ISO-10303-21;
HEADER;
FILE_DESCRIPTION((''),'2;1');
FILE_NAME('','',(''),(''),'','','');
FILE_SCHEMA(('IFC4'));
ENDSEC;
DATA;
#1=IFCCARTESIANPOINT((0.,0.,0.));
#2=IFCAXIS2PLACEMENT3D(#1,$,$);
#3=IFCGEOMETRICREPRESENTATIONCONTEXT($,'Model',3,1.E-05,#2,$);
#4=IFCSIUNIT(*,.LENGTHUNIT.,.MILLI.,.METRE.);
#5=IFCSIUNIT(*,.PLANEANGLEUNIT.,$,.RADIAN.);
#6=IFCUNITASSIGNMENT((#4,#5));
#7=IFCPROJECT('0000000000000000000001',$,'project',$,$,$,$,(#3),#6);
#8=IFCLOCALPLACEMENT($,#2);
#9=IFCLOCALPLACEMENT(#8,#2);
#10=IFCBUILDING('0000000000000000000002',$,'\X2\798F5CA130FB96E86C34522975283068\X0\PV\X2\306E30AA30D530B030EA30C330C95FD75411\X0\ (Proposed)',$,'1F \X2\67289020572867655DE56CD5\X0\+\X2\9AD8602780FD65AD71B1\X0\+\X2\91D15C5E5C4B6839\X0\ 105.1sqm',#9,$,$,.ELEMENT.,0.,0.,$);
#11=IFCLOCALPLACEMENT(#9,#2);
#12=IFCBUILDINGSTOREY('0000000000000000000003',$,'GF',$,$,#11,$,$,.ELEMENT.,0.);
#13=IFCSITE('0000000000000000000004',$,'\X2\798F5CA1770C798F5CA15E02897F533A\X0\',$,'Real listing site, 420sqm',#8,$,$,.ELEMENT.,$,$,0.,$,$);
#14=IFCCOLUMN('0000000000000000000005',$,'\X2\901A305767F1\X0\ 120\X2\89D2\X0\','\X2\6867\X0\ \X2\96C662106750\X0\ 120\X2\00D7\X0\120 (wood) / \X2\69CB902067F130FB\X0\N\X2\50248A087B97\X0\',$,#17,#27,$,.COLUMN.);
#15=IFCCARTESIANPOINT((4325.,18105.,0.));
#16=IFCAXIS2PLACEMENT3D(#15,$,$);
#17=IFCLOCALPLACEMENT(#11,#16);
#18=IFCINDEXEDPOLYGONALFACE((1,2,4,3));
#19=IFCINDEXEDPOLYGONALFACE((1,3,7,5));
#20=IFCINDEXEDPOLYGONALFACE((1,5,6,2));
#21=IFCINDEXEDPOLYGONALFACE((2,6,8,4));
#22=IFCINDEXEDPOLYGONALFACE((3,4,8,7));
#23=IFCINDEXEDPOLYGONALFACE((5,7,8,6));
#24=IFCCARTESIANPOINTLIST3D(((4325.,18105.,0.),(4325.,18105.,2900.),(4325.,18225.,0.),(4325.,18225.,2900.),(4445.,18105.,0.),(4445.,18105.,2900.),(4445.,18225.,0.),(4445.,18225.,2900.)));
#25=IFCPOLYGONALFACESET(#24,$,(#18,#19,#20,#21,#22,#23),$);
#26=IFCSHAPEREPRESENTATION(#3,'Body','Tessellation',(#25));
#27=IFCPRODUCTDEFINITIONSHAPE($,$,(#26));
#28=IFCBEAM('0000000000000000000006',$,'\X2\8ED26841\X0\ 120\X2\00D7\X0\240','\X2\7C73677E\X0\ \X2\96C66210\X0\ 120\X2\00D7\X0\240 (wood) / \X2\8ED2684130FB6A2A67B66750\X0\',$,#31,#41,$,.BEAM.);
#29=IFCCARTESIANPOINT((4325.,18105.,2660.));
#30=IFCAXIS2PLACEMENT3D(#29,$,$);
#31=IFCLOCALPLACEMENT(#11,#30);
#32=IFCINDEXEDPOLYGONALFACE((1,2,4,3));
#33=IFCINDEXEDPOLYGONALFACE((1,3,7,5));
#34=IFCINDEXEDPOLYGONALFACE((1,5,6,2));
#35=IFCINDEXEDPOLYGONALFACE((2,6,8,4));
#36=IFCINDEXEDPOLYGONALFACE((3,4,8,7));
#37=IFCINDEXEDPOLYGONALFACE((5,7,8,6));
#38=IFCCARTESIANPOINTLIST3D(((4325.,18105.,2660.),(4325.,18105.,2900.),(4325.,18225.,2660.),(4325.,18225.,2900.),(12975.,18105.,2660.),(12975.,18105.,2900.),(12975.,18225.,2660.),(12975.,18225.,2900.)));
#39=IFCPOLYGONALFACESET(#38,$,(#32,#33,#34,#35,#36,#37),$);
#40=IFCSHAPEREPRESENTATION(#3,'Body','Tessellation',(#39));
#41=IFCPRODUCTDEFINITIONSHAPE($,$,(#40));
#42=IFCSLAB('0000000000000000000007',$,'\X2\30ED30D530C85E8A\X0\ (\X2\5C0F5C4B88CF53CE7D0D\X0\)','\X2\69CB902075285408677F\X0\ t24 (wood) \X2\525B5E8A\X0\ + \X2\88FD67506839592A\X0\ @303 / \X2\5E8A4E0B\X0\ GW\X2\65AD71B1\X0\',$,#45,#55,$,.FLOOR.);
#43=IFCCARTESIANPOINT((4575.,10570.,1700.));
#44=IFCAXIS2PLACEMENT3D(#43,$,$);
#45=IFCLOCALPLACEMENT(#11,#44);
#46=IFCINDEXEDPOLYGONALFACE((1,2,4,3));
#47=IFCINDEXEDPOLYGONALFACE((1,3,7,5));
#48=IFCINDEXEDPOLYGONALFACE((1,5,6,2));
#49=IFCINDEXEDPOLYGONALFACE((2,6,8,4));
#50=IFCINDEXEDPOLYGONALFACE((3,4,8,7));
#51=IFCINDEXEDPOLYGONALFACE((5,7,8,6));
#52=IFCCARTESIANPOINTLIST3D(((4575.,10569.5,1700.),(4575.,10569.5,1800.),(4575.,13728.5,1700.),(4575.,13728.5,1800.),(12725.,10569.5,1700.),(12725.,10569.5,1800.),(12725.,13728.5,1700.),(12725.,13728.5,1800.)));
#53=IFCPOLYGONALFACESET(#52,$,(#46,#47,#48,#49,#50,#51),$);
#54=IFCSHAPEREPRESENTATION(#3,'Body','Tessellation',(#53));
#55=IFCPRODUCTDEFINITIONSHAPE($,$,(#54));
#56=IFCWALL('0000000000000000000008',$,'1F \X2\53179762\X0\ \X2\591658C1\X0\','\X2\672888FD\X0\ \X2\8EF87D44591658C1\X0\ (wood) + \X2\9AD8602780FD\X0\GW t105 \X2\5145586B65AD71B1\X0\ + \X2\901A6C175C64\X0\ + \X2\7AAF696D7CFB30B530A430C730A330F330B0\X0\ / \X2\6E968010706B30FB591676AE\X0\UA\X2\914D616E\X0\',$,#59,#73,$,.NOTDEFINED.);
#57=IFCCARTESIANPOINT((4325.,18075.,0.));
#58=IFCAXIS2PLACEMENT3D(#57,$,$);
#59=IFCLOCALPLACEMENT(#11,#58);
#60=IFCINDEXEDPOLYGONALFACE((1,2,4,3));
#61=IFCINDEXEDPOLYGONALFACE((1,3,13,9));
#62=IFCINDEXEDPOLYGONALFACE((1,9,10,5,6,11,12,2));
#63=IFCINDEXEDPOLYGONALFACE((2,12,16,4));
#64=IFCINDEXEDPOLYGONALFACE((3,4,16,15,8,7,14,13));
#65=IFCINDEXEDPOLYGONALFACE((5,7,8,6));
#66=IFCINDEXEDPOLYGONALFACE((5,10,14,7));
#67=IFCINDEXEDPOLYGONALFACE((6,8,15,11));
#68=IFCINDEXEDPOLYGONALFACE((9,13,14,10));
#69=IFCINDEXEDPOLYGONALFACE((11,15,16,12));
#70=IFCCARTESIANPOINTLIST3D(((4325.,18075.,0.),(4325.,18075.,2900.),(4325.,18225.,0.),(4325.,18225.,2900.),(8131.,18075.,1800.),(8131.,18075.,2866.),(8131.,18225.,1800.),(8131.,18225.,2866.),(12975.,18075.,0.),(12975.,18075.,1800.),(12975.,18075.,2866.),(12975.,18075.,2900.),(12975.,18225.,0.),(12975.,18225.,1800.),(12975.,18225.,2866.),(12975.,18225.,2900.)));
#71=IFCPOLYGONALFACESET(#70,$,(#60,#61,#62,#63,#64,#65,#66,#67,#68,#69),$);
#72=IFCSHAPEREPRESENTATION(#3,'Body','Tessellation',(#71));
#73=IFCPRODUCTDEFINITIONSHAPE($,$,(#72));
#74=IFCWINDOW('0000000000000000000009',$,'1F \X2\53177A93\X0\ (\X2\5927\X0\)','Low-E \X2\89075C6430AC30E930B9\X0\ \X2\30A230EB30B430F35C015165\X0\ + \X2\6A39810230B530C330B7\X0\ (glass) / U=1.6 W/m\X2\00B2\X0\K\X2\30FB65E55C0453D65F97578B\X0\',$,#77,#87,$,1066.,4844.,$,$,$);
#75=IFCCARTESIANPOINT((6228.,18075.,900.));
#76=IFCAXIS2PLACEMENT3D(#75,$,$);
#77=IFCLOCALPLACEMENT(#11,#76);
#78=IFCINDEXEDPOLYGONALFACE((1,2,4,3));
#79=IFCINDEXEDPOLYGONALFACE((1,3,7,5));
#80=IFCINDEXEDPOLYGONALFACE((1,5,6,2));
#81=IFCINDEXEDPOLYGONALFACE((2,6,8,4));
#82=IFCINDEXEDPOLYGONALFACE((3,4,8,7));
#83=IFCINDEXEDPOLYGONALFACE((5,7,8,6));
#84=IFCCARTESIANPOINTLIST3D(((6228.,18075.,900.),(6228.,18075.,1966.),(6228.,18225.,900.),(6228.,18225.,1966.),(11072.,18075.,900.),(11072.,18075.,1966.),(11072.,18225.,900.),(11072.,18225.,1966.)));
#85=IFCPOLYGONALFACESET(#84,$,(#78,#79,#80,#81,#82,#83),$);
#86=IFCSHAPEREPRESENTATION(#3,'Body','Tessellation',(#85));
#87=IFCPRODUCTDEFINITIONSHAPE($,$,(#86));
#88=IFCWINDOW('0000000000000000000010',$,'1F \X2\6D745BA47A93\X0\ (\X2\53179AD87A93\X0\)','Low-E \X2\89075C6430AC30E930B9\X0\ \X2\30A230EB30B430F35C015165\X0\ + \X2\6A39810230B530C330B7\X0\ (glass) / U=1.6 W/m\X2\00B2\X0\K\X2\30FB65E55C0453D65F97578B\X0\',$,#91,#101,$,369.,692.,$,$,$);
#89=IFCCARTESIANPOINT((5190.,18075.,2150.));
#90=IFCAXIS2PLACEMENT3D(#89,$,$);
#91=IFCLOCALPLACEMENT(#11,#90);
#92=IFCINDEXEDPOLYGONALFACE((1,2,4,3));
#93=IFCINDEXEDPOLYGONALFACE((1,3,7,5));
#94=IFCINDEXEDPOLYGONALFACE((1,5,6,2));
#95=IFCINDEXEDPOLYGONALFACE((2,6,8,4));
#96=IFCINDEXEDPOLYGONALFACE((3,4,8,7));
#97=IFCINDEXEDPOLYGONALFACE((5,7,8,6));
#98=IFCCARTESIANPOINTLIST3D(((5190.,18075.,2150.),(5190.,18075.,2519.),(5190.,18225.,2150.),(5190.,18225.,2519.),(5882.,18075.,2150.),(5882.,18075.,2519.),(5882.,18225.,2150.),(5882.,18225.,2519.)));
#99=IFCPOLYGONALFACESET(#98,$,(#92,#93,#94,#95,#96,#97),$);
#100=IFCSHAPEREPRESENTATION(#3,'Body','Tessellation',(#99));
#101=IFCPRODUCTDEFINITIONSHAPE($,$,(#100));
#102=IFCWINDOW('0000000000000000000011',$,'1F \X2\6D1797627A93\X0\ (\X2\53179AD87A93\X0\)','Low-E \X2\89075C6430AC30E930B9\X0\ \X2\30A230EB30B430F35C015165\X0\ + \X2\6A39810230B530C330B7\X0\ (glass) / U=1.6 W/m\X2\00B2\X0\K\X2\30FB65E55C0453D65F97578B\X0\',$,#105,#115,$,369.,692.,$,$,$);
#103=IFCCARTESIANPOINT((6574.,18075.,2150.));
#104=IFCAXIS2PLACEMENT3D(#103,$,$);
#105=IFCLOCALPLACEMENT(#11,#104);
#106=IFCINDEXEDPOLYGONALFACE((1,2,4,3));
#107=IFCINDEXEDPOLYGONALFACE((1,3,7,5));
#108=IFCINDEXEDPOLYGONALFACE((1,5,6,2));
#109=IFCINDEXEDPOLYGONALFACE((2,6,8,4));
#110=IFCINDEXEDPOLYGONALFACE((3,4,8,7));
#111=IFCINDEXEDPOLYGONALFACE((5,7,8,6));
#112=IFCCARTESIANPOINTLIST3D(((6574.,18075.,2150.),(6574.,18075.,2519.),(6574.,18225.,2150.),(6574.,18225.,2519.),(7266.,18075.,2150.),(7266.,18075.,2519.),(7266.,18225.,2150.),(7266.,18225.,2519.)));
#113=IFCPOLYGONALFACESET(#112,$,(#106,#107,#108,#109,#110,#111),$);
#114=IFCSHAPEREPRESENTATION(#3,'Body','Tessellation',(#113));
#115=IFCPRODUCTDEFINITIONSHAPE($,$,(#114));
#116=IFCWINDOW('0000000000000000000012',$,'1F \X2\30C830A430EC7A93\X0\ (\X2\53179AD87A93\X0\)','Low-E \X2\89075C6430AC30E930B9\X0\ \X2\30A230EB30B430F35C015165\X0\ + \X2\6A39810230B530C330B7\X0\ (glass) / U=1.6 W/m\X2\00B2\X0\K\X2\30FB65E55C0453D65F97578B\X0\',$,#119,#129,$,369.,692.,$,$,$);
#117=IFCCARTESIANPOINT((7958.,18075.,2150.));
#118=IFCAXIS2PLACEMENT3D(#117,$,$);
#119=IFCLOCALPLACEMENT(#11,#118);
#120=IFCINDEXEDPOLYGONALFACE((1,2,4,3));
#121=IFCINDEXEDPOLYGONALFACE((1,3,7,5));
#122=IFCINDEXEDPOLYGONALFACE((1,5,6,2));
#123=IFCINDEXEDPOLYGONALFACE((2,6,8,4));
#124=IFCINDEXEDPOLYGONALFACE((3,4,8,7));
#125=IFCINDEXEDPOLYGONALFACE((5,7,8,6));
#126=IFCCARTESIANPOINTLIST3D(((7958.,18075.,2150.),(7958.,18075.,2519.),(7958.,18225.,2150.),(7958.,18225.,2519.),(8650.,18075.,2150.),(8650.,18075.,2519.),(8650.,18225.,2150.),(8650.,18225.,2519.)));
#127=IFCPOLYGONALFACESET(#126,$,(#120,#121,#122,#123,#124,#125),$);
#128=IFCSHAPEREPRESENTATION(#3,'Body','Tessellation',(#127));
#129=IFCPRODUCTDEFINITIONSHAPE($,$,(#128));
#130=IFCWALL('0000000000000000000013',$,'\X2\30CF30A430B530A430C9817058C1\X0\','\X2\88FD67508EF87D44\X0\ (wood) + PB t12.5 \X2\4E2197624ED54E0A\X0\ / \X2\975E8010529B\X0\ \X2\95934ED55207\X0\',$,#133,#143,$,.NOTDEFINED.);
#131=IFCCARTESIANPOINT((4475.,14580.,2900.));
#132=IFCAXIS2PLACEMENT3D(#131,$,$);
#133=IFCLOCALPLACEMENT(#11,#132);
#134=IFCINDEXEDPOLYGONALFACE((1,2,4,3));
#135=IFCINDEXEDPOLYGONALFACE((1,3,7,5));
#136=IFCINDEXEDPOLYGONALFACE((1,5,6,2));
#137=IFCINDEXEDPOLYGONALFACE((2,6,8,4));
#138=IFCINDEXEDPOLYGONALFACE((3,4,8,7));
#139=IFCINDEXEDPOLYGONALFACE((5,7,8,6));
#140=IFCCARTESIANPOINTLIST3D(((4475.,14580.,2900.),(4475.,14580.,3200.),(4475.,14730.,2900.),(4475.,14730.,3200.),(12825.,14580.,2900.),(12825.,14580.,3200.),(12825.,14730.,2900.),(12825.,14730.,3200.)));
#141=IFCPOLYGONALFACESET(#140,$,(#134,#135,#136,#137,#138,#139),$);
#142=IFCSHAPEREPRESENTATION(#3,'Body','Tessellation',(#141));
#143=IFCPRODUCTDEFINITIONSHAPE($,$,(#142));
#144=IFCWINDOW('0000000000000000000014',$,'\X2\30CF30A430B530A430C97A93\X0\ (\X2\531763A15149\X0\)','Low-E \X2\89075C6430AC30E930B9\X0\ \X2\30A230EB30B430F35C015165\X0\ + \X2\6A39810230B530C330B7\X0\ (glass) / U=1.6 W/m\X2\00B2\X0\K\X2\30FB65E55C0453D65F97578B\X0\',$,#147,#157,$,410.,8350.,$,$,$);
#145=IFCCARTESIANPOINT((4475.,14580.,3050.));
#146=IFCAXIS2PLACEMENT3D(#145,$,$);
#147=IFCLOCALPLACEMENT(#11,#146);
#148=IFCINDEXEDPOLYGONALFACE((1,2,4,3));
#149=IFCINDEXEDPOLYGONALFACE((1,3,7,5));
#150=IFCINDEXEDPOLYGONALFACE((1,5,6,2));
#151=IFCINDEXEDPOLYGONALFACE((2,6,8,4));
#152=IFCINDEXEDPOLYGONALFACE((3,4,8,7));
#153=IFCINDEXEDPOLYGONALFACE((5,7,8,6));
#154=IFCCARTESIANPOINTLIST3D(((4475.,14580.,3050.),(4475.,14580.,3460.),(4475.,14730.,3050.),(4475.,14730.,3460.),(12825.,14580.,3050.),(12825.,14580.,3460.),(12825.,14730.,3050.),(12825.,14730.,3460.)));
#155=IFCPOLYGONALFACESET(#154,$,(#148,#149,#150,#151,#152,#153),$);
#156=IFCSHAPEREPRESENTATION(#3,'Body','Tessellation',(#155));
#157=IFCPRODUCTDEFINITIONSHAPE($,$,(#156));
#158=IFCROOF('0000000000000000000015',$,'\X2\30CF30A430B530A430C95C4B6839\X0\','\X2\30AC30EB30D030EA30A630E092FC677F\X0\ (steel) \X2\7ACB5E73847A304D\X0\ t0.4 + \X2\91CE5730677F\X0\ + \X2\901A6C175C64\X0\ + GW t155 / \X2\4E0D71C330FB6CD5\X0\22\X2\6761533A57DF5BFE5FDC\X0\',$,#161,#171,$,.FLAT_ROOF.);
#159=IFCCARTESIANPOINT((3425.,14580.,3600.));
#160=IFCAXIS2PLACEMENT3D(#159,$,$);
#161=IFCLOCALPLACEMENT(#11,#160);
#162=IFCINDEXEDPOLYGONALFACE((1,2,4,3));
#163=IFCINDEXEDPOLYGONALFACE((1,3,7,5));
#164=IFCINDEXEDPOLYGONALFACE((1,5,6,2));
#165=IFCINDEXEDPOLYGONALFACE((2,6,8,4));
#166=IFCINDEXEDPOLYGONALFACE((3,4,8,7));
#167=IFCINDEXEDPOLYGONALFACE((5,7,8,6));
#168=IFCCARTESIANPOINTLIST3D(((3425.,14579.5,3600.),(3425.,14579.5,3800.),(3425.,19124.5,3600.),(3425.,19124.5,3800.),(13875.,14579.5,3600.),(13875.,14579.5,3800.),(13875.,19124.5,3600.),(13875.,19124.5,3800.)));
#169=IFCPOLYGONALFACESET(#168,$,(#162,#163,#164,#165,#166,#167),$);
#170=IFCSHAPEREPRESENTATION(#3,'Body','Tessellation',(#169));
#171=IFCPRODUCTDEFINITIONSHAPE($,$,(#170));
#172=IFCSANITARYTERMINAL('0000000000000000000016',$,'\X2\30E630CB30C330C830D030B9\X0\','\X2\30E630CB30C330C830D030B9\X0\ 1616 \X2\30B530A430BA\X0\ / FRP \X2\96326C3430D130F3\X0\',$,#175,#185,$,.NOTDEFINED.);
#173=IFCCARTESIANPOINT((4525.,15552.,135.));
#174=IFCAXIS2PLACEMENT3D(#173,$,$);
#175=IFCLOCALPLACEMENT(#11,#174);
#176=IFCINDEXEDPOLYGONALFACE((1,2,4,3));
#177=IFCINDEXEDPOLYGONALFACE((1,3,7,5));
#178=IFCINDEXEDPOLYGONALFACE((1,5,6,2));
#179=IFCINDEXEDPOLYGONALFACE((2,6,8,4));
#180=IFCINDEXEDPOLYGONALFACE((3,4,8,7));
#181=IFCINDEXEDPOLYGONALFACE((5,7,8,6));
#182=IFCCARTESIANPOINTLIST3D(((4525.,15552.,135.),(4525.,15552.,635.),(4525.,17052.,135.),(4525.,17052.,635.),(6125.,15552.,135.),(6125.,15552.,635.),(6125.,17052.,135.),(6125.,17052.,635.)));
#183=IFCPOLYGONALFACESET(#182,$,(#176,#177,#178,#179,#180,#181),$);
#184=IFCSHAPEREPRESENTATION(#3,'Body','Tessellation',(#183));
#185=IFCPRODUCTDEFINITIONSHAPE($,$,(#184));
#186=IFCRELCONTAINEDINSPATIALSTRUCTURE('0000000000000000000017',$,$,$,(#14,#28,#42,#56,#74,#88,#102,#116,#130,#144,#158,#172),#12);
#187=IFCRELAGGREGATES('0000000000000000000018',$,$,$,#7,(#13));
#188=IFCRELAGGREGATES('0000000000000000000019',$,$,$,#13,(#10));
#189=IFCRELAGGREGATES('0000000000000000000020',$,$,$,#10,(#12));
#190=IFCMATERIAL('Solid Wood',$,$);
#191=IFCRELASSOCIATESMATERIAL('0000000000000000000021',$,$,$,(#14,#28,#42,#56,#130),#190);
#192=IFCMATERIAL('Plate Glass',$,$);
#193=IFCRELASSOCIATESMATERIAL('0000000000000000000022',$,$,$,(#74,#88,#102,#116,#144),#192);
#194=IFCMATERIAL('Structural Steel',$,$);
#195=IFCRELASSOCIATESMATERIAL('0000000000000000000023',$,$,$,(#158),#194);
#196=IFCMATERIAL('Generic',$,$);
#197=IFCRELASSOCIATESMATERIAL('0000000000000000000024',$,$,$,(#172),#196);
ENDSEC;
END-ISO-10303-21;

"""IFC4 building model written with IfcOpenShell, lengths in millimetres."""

from ifc_helpers import new_model, si_unit, frame, frame_2d, origin, place, context, project, spatial, rectangle, extrude, material, element, fill, save


model = new_model("IFC4")

# Units and contexts
model_context = context("Model", 3, precision=1e-05, world=origin())
ifc_project = project(units=[si_unit("LENGTHUNIT", "METRE", prefix="MILLI"), si_unit("PLANEANGLEUNIT", "RADIAN")], contexts=[model_context])

# Site, building, storey
site_placement = place(None, origin())
site = spatial("IfcSite", under=ifc_project, at=site_placement, Name="福岡県福岡市西区", ObjectType="Real listing site, 420sqm", CompositionType="ELEMENT", RefElevation=0.0)
building_placement = place(site_placement, origin())
building = spatial("IfcBuilding", under=site, at=building_placement, Name="福岡・雨水利用とPVのオフグリッド志向 (Proposed)", ObjectType="1F 木造在来工法+高性能断熱+金属屋根 105.1sqm", CompositionType="ELEMENT", ElevationOfRefHeight=0.0, ElevationOfTerrain=0.0)
storey_placement = place(building_placement, origin())
storey = spatial("IfcBuildingStorey", under=building, at=storey_placement, Name="GF", CompositionType="ELEMENT", Elevation=0.0)

# Column
ifc_material_1 = material(Name="Solid Wood")
column_1_placement = place(storey_placement, frame((4325.0, 18105.0, 0.0)))
element("IfcColumn", 1, at=column_1_placement, inside=storey, material=ifc_material_1, Name="通し柱 120角", Description="桧 集成材 120×120 (wood) / 構造柱・N値計算", PredefinedType="COLUMN", context=model_context, shape_type="SweptSolid", body=[
    extrude(rectangle(XDim=120.0, YDim=120.0, at=frame_2d((60.0, 60.0))), frame((4325.0, 18105.0, 0.0)), (0.0, 0.0, 1.0), 2900.0),
])

# Beam
beam_1_placement = place(storey_placement, frame((4325.0, 18105.0, 2660.0)))
element("IfcBeam", 2, at=beam_1_placement, inside=storey, material=ifc_material_1, Name="軒桁 120×240", Description="米松 集成 120×240 (wood) / 軒桁・横架材", PredefinedType="BEAM", context=model_context, shape_type="SweptSolid", body=[
    extrude(rectangle(XDim=8650.0, YDim=120.0, at=frame_2d((4325.0, 60.0))), frame((4325.0, 18105.0, 2660.0)), (0.0, 0.0, 1.0), 240.0),
])

# Slab
slab_placement = place(storey_placement, frame((4575.0, 10570.0, 1700.0)))
element("IfcSlab", 3, at=slab_placement, inside=storey, material=ifc_material_1, Name="ロフト床 (小屋裏収納)", Description="構造用合板 t24 (wood) 剛床 + 製材根太 @303 / 床下 GW断熱", PredefinedType="FLOOR", context=model_context, shape_type="SweptSolid", body=[
    extrude(rectangle(XDim=8150.0, YDim=3159.0, at=frame_2d((4075.0, 1579.0))), frame((4575.0, 10570.0, 1700.0)), (0.0, 0.0, 1.0), 100.0),
])

# Wall, openings, windows
wall_1_placement = place(storey_placement, frame((4325.0, 18075.0, 0.0)))
wall_1 = element("IfcWall", 4, at=wall_1_placement, inside=storey, material=ifc_material_1, Name="1F 北面 外壁", Description="木製 軸組外壁 (wood) + 高性能GW t105 充填断熱 + 通気層 + 窯業系サイディング / 準耐火・外皮UA配慮", PredefinedType="NOTDEFINED", context=model_context, shape_type="SweptSolid", body=[
    extrude(rectangle(XDim=8650.0, YDim=150.0, at=frame_2d((4325.0, 75.0))), frame((4325.0, 18075.0, 0.0)), (0.0, 0.0, 1.0), 2900.0),
])
opening_1_placement = place(storey_placement, frame((6228.0, 18075.0, 900.0)))
opening_1 = element("IfcOpeningElement", 5, at=opening_1_placement, cuts=wall_1, PredefinedType="NOTDEFINED", context=model_context, shape_type="SweptSolid", body=[
    extrude(rectangle(XDim=4844.0, YDim=150.0, at=frame_2d((2422.0, 75.0))), frame((6228.0, 18075.0, 900.0)), (0.0, 0.0, 1.0), 1066.0),
])
opening_2_placement = place(storey_placement, frame((5190.0, 18075.0, 2150.0)))
opening_2 = element("IfcOpeningElement", 6, at=opening_2_placement, cuts=wall_1, PredefinedType="NOTDEFINED", context=model_context, shape_type="SweptSolid", body=[
    extrude(rectangle(XDim=692.0, YDim=150.0, at=frame_2d((346.0, 75.0))), frame((5190.0, 18075.0, 2150.0)), (0.0, 0.0, 1.0), 369.0),
])
opening_3_placement = place(storey_placement, frame((6574.0, 18075.0, 2150.0)))
opening_3 = element("IfcOpeningElement", 7, at=opening_3_placement, cuts=wall_1, PredefinedType="NOTDEFINED", context=model_context, shape_type="SweptSolid", body=[
    extrude(rectangle(XDim=692.0, YDim=150.0, at=frame_2d((346.0, 75.0))), frame((6574.0, 18075.0, 2150.0)), (0.0, 0.0, 1.0), 369.0),
])
opening_4_placement = place(storey_placement, frame((7958.0, 18075.0, 2150.0)))
opening_4 = element("IfcOpeningElement", 8, at=opening_4_placement, cuts=wall_1, PredefinedType="NOTDEFINED", context=model_context, shape_type="SweptSolid", body=[
    extrude(rectangle(XDim=692.0, YDim=150.0, at=frame_2d((346.0, 75.0))), frame((7958.0, 18075.0, 2150.0)), (0.0, 0.0, 1.0), 369.0),
])
ifc_material_2 = material(Name="Plate Glass")
window_1_placement = place(storey_placement, frame((6228.0, 18075.0, 900.0)))
window_1 = element("IfcWindow", 9, at=window_1_placement, inside=storey, material=ifc_material_2, Name="1F 北窓 (大)", Description="Low-E 複層ガラス アルゴン封入 + 樹脂サッシ (glass) / U=1.6 W/m²K・日射取得型", OverallHeight=1066.0, OverallWidth=4844.0, context=model_context, shape_type="SweptSolid", body=[
    extrude(rectangle(XDim=4844.0, YDim=150.0, at=frame_2d((2422.0, 75.0))), frame((6228.0, 18075.0, 900.0)), (0.0, 0.0, 1.0), 1066.0),
])
fill(opening_1, window_1)
window_2_placement = place(storey_placement, frame((5190.0, 18075.0, 2150.0)))
window_2 = element("IfcWindow", 10, at=window_2_placement, inside=storey, material=ifc_material_2, Name="1F 浴室窓 (北高窓)", Description="Low-E 複層ガラス アルゴン封入 + 樹脂サッシ (glass) / U=1.6 W/m²K・日射取得型", OverallHeight=369.0, OverallWidth=692.0, context=model_context, shape_type="SweptSolid", body=[
    extrude(rectangle(XDim=692.0, YDim=150.0, at=frame_2d((346.0, 75.0))), frame((5190.0, 18075.0, 2150.0)), (0.0, 0.0, 1.0), 369.0),
])
fill(opening_2, window_2)
window_3_placement = place(storey_placement, frame((6574.0, 18075.0, 2150.0)))
window_3 = element("IfcWindow", 11, at=window_3_placement, inside=storey, material=ifc_material_2, Name="1F 洗面窓 (北高窓)", Description="Low-E 複層ガラス アルゴン封入 + 樹脂サッシ (glass) / U=1.6 W/m²K・日射取得型", OverallHeight=369.0, OverallWidth=692.0, context=model_context, shape_type="SweptSolid", body=[
    extrude(rectangle(XDim=692.0, YDim=150.0, at=frame_2d((346.0, 75.0))), frame((6574.0, 18075.0, 2150.0)), (0.0, 0.0, 1.0), 369.0),
])
fill(opening_3, window_3)
window_4_placement = place(storey_placement, frame((7958.0, 18075.0, 2150.0)))
window_4 = element("IfcWindow", 12, at=window_4_placement, inside=storey, material=ifc_material_2, Name="1F トイレ窓 (北高窓)", Description="Low-E 複層ガラス アルゴン封入 + 樹脂サッシ (glass) / U=1.6 W/m²K・日射取得型", OverallHeight=369.0, OverallWidth=692.0, context=model_context, shape_type="SweptSolid", body=[
    extrude(rectangle(XDim=692.0, YDim=150.0, at=frame_2d((346.0, 75.0))), frame((7958.0, 18075.0, 2150.0)), (0.0, 0.0, 1.0), 369.0),
])
fill(opening_4, window_4)

# Wall, opening, window
wall_2_placement = place(storey_placement, frame((4475.0, 14580.0, 2900.0)))
wall_2 = element("IfcWall", 13, at=wall_2_placement, inside=storey, material=ifc_material_1, Name="ハイサイド腰壁", Description="製材軸組 (wood) + PB t12.5 両面仕上 / 非耐力 間仕切", PredefinedType="NOTDEFINED", context=model_context, shape_type="SweptSolid", body=[
    extrude(rectangle(XDim=8350.0, YDim=150.0, at=frame_2d((4175.0, 75.0))), frame((4475.0, 14580.0, 2900.0)), (0.0, 0.0, 1.0), 700.0),
])
opening_5_placement = place(storey_placement, frame((4475.0, 14580.0, 3050.0)))
opening_5 = element("IfcOpeningElement", 14, at=opening_5_placement, cuts=wall_2, PredefinedType="NOTDEFINED", context=model_context, shape_type="SweptSolid", body=[
    extrude(rectangle(XDim=8350.0, YDim=150.0, at=frame_2d((4175.0, 75.0))), frame((4475.0, 14580.0, 3050.0)), (0.0, 0.0, 1.0), 410.0),
])
window_5_placement = place(storey_placement, frame((4475.0, 14580.0, 3050.0)))
window_5 = element("IfcWindow", 15, at=window_5_placement, inside=storey, material=ifc_material_2, Name="ハイサイド窓 (北採光)", Description="Low-E 複層ガラス アルゴン封入 + 樹脂サッシ (glass) / U=1.6 W/m²K・日射取得型", OverallHeight=410.0, OverallWidth=8350.0, context=model_context, shape_type="SweptSolid", body=[
    extrude(rectangle(XDim=8350.0, YDim=150.0, at=frame_2d((4175.0, 75.0))), frame((4475.0, 14580.0, 3050.0)), (0.0, 0.0, 1.0), 410.0),
])
fill(opening_5, window_5)

# Roof
ifc_material_3 = material(Name="Structural Steel")
roof_placement = place(storey_placement, frame((3425.0, 14580.0, 3600.0)))
element("IfcRoof", 16, at=roof_placement, inside=storey, material=ifc_material_3, Name="ハイサイド屋根", Description="ガルバリウム鋼板 (steel) 立平葺き t0.4 + 野地板 + 通気層 + GW t155 / 不燃・法22条区域対応", PredefinedType="FLAT_ROOF", context=model_context, shape_type="SweptSolid", body=[
    extrude(rectangle(XDim=10450.0, YDim=4545.0, at=frame_2d((5225.0, 2272.0))), frame((3425.0, 14580.0, 3600.0)), (0.0, 0.0, 1.0), 200.0),
])

# Sanitary terminal
ifc_material_4 = material(Name="Generic")
sanitary_terminal_placement = place(storey_placement, frame((4525.0, 15552.0, 135.0)))
element("IfcSanitaryTerminal", 17, at=sanitary_terminal_placement, inside=storey, material=ifc_material_4, Name="ユニットバス", Description="ユニットバス 1616 サイズ / FRP 防水パン", PredefinedType="NOTDEFINED", context=model_context, shape_type="SweptSolid", body=[
    extrude(rectangle(XDim=1600.0, YDim=1500.0, at=frame_2d((800.0, 750.0))), frame((4525.0, 15552.0, 135.0)), (0.0, 0.0, 1.0), 500.0),
])

save(model, "model.ifc")
